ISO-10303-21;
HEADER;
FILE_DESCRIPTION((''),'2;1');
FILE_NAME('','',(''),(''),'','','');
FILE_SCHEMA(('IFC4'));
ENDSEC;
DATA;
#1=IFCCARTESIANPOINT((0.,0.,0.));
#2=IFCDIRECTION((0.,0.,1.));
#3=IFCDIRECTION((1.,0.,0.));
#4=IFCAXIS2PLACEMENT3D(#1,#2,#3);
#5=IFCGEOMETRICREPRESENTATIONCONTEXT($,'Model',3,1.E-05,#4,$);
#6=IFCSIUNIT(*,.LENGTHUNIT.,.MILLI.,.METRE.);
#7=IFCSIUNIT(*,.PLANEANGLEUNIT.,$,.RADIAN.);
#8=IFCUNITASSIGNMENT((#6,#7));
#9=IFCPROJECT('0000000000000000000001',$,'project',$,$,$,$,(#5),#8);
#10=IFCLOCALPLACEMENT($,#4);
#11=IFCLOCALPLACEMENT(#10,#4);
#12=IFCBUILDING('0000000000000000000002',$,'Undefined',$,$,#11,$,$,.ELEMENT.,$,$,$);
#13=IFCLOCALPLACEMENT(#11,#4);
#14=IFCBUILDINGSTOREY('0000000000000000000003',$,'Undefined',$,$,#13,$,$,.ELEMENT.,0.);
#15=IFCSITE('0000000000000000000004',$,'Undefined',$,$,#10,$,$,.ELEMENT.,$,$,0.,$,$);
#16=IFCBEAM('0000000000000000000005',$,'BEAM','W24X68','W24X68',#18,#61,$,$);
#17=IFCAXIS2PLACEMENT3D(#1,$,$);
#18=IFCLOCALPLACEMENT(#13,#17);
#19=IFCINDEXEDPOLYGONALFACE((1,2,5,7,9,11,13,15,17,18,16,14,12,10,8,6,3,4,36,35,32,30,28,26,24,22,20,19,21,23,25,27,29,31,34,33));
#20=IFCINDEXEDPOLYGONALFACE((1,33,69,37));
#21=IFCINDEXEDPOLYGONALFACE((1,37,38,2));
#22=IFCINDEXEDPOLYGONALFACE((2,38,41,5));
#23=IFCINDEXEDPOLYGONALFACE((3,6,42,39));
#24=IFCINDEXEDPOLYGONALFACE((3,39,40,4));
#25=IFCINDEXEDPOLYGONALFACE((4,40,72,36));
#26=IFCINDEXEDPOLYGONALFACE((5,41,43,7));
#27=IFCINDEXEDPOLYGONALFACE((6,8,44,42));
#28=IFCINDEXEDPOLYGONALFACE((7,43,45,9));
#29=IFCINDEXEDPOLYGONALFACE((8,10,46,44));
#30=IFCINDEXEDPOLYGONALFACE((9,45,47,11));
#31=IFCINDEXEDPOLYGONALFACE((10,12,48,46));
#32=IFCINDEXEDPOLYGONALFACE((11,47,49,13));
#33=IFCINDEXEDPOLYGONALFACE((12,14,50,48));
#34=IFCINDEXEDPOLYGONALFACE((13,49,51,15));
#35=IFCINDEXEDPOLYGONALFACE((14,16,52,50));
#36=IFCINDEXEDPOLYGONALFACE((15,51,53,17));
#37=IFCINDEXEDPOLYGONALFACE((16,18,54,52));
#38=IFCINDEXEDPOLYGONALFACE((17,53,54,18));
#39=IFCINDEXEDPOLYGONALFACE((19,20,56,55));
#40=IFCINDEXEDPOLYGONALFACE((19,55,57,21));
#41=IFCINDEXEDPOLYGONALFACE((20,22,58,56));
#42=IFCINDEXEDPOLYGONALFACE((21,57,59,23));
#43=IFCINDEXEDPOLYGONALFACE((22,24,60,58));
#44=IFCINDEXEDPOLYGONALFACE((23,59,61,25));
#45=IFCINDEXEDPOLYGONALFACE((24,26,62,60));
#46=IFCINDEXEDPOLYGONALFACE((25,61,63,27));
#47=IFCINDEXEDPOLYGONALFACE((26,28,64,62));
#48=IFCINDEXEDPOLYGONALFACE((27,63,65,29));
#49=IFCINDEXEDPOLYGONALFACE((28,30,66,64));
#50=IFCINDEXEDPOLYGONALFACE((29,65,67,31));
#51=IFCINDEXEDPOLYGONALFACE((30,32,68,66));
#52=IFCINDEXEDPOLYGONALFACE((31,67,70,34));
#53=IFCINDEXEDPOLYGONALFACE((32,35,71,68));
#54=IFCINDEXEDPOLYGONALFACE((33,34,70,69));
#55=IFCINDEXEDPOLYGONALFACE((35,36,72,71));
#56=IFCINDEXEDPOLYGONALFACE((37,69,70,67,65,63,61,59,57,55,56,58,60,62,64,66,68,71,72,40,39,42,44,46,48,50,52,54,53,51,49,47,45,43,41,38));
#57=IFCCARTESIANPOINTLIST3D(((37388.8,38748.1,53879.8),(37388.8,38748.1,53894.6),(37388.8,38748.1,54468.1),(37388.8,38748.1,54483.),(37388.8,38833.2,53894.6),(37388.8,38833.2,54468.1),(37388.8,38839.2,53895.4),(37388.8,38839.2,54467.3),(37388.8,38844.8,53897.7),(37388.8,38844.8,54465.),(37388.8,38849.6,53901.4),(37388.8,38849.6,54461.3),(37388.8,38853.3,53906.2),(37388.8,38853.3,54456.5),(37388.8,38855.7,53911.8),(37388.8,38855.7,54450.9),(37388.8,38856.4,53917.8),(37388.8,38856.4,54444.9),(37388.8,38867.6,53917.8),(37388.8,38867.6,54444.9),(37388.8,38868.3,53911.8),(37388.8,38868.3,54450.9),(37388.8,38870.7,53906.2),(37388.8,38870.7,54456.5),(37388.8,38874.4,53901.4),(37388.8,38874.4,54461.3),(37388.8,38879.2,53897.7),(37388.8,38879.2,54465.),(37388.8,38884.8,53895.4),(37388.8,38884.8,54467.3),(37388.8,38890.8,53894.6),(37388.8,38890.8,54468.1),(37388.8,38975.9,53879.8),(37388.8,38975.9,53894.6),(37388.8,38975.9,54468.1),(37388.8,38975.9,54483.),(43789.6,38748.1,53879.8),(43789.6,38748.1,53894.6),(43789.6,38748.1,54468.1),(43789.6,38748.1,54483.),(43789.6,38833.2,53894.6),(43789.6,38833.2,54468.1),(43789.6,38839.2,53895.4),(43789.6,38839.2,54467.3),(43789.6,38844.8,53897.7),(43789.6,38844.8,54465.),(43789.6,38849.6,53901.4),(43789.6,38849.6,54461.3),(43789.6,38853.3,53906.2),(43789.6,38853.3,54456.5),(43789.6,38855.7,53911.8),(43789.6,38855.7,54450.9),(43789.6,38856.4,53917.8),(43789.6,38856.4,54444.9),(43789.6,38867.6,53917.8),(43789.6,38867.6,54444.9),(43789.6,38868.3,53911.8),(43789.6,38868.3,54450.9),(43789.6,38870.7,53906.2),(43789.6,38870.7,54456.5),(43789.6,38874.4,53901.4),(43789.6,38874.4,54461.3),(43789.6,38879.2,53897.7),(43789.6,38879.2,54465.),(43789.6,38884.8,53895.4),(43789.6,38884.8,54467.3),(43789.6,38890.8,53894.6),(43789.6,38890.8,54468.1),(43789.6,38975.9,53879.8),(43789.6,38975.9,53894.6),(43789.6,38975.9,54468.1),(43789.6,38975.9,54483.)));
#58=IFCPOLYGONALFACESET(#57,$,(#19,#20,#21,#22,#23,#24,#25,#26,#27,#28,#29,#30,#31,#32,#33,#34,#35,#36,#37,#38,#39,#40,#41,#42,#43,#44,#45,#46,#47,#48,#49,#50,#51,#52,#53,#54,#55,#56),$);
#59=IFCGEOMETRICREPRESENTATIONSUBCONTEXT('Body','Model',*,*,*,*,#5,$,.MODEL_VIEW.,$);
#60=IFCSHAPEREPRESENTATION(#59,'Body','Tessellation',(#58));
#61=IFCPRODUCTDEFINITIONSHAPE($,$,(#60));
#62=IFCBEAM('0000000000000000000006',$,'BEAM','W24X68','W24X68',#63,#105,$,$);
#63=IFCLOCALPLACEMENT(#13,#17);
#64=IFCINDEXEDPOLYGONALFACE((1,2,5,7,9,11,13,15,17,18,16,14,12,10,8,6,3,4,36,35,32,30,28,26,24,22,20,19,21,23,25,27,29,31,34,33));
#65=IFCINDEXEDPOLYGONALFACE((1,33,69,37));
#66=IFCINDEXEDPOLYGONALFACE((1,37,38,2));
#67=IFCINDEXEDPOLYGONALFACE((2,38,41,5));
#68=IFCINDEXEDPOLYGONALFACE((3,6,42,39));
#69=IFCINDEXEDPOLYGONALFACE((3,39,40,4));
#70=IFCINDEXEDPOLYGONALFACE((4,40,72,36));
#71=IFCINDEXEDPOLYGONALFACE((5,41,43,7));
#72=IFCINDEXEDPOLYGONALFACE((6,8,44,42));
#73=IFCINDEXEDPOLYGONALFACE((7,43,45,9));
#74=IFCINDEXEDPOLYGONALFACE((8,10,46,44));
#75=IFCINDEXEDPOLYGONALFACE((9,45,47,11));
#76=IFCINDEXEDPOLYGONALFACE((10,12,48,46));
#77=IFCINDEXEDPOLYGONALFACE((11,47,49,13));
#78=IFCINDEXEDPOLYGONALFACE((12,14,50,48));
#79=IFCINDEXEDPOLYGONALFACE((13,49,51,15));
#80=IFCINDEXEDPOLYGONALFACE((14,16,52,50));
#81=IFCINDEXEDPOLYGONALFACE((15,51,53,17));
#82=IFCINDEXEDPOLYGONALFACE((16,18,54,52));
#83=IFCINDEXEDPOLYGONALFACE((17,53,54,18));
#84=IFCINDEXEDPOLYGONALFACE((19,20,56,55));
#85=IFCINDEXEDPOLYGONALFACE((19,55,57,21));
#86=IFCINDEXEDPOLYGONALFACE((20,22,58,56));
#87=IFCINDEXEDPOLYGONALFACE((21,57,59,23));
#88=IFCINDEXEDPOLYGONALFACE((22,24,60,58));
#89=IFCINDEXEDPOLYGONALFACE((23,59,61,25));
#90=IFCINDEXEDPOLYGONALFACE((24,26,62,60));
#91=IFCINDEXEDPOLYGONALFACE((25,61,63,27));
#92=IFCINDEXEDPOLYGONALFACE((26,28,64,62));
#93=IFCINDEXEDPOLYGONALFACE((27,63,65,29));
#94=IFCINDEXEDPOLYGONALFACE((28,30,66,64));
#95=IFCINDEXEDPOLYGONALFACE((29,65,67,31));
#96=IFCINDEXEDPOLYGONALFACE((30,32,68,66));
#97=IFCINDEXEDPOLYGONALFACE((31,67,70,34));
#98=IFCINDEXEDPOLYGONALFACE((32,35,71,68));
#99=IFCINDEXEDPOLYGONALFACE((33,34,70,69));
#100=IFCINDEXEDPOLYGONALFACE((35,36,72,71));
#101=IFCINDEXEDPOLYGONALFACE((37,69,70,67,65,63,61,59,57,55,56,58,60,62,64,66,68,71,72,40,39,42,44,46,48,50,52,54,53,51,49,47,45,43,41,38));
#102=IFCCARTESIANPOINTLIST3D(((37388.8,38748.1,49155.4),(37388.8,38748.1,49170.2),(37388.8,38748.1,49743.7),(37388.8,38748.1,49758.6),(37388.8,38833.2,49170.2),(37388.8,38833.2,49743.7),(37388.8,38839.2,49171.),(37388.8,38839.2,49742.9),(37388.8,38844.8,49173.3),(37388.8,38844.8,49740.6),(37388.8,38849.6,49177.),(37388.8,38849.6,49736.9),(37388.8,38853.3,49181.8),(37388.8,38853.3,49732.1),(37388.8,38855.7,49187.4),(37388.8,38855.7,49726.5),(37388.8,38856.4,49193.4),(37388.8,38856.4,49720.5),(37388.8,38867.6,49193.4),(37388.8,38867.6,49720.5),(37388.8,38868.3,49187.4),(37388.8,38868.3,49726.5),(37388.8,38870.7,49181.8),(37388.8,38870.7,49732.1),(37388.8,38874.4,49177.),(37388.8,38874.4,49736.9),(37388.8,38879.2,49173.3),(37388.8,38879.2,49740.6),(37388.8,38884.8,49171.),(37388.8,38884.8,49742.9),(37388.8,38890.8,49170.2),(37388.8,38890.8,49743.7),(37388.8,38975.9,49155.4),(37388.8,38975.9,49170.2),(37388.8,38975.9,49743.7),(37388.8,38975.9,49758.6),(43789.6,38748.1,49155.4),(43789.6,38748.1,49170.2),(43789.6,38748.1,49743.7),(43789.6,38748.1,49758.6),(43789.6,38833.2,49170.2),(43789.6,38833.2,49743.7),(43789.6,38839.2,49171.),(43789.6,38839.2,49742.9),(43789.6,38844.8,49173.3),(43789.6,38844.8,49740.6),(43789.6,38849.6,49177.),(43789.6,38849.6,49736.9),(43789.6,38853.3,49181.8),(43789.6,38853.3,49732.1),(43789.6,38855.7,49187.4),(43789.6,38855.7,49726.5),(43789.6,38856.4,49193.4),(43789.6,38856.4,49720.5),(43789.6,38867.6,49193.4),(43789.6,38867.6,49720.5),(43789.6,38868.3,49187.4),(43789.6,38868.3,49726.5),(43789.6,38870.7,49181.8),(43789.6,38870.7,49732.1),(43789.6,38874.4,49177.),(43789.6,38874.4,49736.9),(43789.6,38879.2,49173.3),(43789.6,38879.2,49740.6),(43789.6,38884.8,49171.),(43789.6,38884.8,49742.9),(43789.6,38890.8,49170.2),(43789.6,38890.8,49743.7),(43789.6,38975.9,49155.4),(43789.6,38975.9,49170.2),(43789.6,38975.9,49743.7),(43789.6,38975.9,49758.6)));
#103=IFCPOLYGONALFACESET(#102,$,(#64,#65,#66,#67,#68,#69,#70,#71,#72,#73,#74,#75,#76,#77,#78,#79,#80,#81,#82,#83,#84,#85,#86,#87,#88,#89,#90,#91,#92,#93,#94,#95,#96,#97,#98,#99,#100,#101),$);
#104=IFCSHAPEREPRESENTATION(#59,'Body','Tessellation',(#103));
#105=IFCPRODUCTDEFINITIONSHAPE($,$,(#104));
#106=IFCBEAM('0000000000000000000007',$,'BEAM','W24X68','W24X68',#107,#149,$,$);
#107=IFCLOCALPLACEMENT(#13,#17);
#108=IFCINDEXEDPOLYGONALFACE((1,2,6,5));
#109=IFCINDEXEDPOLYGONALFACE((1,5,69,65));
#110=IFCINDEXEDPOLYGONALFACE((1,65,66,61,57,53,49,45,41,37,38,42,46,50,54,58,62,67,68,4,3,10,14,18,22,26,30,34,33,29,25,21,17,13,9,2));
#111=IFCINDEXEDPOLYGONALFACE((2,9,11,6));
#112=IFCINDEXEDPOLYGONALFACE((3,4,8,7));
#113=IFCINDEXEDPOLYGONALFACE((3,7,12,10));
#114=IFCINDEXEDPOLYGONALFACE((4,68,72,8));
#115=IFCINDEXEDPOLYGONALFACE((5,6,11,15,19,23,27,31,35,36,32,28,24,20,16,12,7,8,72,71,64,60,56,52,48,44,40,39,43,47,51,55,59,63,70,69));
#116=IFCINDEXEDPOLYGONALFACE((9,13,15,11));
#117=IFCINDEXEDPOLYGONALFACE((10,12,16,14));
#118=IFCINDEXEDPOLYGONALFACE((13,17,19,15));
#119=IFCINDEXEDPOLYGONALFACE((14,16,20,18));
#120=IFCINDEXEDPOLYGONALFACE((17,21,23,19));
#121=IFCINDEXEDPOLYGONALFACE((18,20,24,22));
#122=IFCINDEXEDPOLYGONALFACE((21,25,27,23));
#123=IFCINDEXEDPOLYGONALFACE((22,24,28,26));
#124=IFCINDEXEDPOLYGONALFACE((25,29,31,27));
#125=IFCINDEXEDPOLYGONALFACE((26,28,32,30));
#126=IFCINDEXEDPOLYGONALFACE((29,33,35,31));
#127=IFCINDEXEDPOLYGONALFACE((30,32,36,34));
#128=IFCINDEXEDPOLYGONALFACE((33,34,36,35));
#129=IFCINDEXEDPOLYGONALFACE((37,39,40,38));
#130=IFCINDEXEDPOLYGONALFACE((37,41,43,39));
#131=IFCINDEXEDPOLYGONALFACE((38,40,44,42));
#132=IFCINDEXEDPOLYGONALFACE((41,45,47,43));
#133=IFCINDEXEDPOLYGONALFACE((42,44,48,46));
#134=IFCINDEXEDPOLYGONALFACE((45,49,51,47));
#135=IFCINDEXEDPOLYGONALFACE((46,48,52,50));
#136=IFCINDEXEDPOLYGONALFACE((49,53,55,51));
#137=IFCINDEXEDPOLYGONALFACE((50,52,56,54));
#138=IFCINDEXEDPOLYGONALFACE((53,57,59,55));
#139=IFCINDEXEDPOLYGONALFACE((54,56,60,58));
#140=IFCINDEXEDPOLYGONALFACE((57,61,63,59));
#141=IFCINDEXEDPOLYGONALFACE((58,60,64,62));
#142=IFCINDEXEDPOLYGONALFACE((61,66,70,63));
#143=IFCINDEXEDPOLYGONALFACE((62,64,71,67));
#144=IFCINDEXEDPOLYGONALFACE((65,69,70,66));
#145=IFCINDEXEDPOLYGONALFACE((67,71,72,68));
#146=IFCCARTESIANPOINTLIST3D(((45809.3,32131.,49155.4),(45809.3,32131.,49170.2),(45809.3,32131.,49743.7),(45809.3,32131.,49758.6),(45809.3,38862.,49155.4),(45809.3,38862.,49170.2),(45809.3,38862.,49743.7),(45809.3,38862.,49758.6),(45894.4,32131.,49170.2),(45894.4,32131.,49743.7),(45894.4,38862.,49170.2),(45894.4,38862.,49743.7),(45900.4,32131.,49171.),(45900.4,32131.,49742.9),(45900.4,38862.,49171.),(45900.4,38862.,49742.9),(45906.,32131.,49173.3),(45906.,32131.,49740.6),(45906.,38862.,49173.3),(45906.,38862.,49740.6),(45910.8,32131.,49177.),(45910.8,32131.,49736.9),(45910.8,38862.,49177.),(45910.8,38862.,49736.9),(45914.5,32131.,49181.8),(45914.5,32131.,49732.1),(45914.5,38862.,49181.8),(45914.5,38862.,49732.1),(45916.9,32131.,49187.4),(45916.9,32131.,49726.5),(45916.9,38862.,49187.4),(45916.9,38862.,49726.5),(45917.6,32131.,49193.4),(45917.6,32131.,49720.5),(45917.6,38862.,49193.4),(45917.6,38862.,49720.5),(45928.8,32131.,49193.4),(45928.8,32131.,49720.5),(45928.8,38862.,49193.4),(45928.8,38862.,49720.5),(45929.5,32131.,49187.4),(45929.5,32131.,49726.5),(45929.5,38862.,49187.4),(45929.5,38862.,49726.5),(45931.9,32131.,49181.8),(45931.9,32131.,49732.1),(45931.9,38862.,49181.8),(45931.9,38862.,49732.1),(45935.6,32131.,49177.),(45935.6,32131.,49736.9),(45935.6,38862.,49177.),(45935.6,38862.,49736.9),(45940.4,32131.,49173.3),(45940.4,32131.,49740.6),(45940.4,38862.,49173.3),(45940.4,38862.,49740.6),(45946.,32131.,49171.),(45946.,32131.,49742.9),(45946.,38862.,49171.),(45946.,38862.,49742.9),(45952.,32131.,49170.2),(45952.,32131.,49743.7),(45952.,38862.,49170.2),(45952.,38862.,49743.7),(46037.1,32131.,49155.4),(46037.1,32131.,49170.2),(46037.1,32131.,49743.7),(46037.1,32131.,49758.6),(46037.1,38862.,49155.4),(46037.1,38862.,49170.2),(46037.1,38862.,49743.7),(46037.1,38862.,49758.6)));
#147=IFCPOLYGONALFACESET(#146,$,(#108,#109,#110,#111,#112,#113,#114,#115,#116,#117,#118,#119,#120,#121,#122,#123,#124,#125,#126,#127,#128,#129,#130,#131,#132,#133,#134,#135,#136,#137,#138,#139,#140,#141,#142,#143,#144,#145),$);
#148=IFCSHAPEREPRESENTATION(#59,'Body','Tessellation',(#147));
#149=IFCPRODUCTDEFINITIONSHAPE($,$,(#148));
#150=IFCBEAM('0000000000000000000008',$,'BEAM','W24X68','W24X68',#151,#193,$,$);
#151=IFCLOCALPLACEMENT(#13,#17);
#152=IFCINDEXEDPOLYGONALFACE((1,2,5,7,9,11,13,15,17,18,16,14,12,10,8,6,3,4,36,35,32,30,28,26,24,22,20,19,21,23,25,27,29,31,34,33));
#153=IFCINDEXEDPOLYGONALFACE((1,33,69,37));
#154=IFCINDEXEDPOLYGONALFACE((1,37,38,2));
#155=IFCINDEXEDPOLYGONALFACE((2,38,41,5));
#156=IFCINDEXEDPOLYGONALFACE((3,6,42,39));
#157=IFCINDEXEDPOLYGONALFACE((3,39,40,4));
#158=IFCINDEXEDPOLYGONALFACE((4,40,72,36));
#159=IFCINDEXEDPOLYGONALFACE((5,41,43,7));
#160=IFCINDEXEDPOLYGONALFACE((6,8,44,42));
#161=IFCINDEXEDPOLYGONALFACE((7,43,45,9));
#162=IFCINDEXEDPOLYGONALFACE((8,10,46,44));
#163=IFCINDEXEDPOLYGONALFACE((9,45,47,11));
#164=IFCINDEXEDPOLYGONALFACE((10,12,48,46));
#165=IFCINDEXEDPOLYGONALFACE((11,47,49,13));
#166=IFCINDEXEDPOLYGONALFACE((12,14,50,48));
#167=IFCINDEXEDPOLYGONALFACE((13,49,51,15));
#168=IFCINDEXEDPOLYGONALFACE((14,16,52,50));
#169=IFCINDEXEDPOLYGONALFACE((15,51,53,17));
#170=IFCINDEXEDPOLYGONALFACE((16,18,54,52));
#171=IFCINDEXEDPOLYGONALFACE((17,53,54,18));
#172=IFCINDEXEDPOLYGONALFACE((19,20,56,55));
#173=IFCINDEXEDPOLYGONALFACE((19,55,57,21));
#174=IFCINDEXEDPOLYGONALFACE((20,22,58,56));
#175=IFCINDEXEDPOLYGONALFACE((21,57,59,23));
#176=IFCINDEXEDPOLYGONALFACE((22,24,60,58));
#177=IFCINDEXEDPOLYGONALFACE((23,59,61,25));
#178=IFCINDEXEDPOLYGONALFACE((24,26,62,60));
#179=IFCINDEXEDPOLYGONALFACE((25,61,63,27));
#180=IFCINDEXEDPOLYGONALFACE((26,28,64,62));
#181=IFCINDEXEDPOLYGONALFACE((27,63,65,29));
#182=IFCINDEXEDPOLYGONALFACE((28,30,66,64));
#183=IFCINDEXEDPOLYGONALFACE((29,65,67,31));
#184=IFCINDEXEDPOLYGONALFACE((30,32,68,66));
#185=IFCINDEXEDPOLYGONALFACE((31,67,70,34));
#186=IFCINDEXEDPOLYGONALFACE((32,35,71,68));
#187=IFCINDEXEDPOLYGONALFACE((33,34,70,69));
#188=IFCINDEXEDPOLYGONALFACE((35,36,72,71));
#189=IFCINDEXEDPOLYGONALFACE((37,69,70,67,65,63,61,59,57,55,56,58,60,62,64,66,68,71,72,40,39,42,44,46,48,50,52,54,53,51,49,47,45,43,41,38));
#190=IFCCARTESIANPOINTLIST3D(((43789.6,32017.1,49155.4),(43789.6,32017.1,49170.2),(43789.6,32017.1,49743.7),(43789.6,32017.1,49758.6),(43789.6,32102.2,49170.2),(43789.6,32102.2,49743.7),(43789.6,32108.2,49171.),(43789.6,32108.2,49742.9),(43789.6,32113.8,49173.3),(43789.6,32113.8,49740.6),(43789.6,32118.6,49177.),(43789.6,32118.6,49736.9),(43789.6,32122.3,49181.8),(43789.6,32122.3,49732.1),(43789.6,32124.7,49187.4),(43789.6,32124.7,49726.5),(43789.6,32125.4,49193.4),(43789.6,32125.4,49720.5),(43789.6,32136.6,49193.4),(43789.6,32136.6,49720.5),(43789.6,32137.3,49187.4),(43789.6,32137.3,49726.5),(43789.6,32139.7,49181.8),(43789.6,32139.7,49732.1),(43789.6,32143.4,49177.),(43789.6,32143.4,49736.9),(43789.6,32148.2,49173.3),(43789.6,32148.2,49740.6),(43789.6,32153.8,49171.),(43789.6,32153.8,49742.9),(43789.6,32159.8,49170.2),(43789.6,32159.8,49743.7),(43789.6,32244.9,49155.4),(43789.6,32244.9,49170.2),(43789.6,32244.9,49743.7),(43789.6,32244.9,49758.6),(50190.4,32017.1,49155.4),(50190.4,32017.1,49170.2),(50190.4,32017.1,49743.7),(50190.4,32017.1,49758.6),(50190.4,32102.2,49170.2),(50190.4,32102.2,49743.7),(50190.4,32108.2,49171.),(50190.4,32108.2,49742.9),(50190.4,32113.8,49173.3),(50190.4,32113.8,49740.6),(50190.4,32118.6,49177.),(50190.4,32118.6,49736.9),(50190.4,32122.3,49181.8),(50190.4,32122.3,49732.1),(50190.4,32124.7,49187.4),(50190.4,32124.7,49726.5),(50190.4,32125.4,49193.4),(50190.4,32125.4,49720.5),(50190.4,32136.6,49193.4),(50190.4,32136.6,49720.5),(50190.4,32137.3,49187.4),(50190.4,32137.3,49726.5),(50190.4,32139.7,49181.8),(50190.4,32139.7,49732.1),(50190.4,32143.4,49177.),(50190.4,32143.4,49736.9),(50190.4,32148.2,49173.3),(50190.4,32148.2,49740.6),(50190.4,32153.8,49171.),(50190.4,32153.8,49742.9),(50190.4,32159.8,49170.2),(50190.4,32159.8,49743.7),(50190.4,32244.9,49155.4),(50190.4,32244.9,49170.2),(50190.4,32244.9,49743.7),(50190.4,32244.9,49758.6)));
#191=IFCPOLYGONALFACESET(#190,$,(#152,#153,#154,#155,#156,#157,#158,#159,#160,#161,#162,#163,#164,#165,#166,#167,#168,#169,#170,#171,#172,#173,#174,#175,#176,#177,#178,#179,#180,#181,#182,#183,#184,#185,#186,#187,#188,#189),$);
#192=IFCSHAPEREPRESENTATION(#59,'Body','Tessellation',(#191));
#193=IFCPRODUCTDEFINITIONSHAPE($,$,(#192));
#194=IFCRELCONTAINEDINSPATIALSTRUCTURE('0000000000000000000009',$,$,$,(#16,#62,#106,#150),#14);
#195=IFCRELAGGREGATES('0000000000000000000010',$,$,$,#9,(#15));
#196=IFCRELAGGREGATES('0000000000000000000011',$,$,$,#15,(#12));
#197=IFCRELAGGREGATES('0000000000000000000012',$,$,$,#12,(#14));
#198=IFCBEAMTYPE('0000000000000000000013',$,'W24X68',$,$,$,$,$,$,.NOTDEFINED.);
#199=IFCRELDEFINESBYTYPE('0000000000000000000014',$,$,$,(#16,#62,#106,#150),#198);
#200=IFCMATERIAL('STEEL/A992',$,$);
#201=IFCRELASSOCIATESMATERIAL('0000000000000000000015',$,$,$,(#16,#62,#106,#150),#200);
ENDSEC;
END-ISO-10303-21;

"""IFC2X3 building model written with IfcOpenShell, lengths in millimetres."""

from ifc_helpers import new_model, si_unit, frame, origin_with_axes, origin_2d_with_axis, place, context, subcontext, project, spatial, i_section, extrude, material, type_object, element, save


model = new_model("IFC2X3")

# Units and contexts
model_context = context("Model", 3, precision=1e-05, world=origin_with_axes())
body_context = subcontext(model_context, "Body", "Model", "MODEL_VIEW")
ifc_project = project(units=[si_unit("LENGTHUNIT", "METRE", prefix="MILLI"), si_unit("PLANEANGLEUNIT", "RADIAN")], contexts=[model_context])

# Site, building, storey
site_placement = place(None, origin_with_axes())
site = spatial("IfcSite", under=ifc_project, at=site_placement, Name="Undefined", CompositionType="ELEMENT", RefElevation=0.0)
building_placement = place(site_placement, origin_with_axes())
building = spatial("IfcBuilding", under=site, at=building_placement, Name="Undefined", CompositionType="ELEMENT")
storey_placement = place(building_placement, origin_with_axes())
storey = spatial("IfcBuildingStorey", under=building, at=storey_placement, Name="Undefined", CompositionType="ELEMENT", Elevation=0.0)

# Shared definitions
ifc_material = material(Name="STEEL/A992")

# Beams
beam_type_1 = type_object("IfcBeamType", Name="W24X68", PredefinedType="NOTDEFINED")
for number, where, z_axis, x_axis, name in (
    (1, (37388.8, 38862.0, 54181.4), (0.0, 0.0, 1.0), (1.0, 0.0, 0.0), "BEAM"),
    (2, (37388.8, 38862.0, 49457.0), (0.0, 0.0, 1.0), (1.0, 0.0, 0.0), "BEAM"),
):
    element("IfcBeam", number, at=place(storey_placement, frame(where, z_axis=z_axis, x_axis=x_axis)), inside=storey, type_object=beam_type_1, material=ifc_material, Name=name, Description="W24X68", ObjectType="W24X68", context=body_context, shape_type="SweptSolid", body=[
        extrude(i_section(OverallWidth=227.8, OverallDepth=603.2, WebThickness=11.1, FlangeThickness=14.9, FilletRadius=23.2, at=origin_2d_with_axis()), frame((6400.8, 0.0, 0.0), z_axis=(-1.0, 0.0, 0.0), x_axis=(0.0, -1.0, 0.0)), (0.0, 0.0, 1.0), 6400.8),
    ])
beam_1_placement = place(storey_placement, frame((45923.2, 32131.0, 49457.0), z_axis=(0.0, 0.0, 1.0), x_axis=(0.0, 1.0, 0.0)))
element("IfcBeam", 3, at=beam_1_placement, inside=storey, type_object=beam_type_1, material=ifc_material, Name="BEAM", Description="W24X68", ObjectType="W24X68", context=body_context, shape_type="SweptSolid", body=[
    extrude(i_section(OverallWidth=227.8, OverallDepth=603.2, WebThickness=11.1, FlangeThickness=14.9, FilletRadius=23.2, at=origin_2d_with_axis()), frame((6731.0, 0.0, 0.0), z_axis=(-1.0, 0.0, 0.0), x_axis=(0.0, -1.0, 0.0)), (0.0, 0.0, 1.0), 6731.0),
])
beam_2_placement = place(storey_placement, frame((43789.6, 32131.0, 49457.0), z_axis=(0.0, 0.0, 1.0), x_axis=(1.0, 0.0, 0.0)))
element("IfcBeam", 4, at=beam_2_placement, inside=storey, type_object=beam_type_1, material=ifc_material, Name="BEAM", Description="W24X68", ObjectType="W24X68", context=body_context, shape_type="SweptSolid", body=[
    extrude(i_section(OverallWidth=227.8, OverallDepth=603.2, WebThickness=11.1, FlangeThickness=14.9, FilletRadius=23.2, at=origin_2d_with_axis()), frame((6400.8, 0.0, 0.0), z_axis=(-1.0, 0.0, 0.0), x_axis=(0.0, -1.0, 0.0)), (0.0, 0.0, 1.0), 6400.8),
])

save(model, "model.ifc")
